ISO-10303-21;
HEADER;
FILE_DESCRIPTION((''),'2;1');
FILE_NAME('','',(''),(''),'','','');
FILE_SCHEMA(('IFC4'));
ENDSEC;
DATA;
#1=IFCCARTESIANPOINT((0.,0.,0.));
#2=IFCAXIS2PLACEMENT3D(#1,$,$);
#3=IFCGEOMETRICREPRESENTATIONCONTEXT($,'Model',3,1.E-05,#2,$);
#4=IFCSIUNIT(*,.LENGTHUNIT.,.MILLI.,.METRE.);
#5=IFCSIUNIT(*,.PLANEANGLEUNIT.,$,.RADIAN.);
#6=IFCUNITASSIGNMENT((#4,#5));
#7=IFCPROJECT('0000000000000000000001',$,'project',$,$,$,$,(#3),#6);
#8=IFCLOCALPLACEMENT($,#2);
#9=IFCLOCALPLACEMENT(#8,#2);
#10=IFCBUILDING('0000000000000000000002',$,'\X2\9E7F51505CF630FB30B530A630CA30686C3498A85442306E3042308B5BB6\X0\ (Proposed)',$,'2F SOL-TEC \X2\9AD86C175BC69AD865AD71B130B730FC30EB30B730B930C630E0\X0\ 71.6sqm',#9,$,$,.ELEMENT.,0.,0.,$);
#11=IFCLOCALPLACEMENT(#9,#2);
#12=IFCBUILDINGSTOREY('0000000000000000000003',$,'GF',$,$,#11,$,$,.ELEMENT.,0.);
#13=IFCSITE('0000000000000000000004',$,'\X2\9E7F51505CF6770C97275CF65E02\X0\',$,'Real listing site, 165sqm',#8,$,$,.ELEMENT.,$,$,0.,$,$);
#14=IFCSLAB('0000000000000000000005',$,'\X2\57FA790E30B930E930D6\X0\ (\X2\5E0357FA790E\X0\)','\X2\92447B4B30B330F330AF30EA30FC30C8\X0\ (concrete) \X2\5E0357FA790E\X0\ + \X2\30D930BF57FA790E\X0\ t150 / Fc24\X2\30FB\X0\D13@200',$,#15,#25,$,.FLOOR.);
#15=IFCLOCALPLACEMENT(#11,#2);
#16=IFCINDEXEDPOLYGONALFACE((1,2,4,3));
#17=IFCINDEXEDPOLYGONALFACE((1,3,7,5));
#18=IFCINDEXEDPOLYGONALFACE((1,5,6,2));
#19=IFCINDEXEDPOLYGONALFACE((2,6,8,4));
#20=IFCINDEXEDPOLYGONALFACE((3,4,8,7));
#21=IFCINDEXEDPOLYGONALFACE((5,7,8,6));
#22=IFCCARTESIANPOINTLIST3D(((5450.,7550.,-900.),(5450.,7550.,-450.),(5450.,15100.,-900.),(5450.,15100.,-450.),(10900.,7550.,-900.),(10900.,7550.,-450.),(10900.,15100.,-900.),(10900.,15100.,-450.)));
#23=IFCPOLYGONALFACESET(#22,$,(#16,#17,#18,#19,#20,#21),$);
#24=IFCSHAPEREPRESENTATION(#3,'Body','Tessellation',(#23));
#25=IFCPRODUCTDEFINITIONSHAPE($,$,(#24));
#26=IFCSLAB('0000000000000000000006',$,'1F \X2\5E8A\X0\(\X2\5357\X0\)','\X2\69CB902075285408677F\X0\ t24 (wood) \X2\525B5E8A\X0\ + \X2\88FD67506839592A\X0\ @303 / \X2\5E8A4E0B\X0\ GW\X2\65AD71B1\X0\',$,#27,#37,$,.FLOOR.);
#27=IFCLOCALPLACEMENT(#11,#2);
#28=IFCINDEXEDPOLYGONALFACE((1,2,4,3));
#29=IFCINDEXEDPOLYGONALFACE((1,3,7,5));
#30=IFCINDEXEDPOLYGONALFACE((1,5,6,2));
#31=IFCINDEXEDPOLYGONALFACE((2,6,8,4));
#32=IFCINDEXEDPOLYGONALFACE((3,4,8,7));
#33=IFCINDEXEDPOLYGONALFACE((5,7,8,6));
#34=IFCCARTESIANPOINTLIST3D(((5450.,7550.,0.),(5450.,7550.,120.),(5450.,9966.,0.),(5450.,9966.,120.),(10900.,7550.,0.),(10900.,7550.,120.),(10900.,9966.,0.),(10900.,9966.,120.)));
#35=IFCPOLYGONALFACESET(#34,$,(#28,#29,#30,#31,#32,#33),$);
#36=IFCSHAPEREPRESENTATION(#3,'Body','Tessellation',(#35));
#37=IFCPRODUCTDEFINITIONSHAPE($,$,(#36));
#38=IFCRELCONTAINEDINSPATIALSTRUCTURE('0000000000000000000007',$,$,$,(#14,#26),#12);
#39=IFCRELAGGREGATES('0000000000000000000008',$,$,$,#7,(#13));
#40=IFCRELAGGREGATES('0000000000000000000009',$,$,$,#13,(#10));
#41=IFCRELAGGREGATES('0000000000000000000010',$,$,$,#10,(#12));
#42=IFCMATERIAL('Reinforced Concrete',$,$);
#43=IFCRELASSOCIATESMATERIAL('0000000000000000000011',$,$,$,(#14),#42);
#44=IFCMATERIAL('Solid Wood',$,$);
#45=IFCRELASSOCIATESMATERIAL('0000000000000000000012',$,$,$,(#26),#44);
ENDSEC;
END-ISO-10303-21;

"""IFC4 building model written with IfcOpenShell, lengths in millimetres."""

from ifc_helpers import new_model, si_unit, frame, frame_2d, origin, place, context, project, spatial, rectangle, extrude, material, element, save


model = new_model("IFC4")

# Units and contexts
model_context = context("Model", 3, precision=1e-05, world=origin())
ifc_project = project(units=[si_unit("LENGTHUNIT", "METRE", prefix="MILLI"), si_unit("PLANEANGLEUNIT", "RADIAN")], contexts=[model_context])

# Site, building, storey
site_placement = place(None, origin())
site = spatial("IfcSite", under=ifc_project, at=site_placement, Name="鹿児島県霧島市", ObjectType="Real listing site, 165sqm", CompositionType="ELEMENT", RefElevation=0.0)
building_placement = place(site_placement, origin())
building = spatial("IfcBuilding", under=site, at=building_placement, Name="鹿児島・サウナと水風呂のある家 (Proposed)", ObjectType="2F SOL-TEC 高気密高断熱シールシステム 71.6sqm", CompositionType="ELEMENT", ElevationOfRefHeight=0.0, ElevationOfTerrain=0.0)
storey_placement = place(building_placement, origin())
storey = spatial("IfcBuildingStorey", under=building, at=storey_placement, Name="GF", CompositionType="ELEMENT", Elevation=0.0)

# Shared definitions
ifc_material_1 = material(Name="Solid Wood")

# Slabs
ifc_material_2 = material(Name="Reinforced Concrete")
slab_1_placement = place(storey_placement, frame((2725.0, 3775.0, -450.0)))
element("IfcSlab", 1, at=slab_1_placement, inside=storey, material=ifc_material_2, Name="基礎スラブ (布基礎)", Description="鉄筋コンクリート (concrete) 布基礎 + ベタ基礎 t150 / Fc24・D13@200", PredefinedType="FLOOR", context=model_context, shape_type="SweptSolid", body=[
    extrude(rectangle(XDim=5450.0, YDim=7550.0, at=frame_2d((2725.0, 3775.0))), frame((2725.0, 3775.0, -450.0)), (0.0, 0.0, 1.0), 450.0),
])
slab_2_placement = place(storey_placement, frame((2725.0, 3775.0, 0.0)))
element("IfcSlab", 2, at=slab_2_placement, inside=storey, material=ifc_material_1, Name="1F 床(南)", Description="構造用合板 t24 (wood) 剛床 + 製材根太 @303 / 床下 GW断熱", PredefinedType="FLOOR", context=model_context, shape_type="SweptSolid", body=[
    extrude(rectangle(XDim=5450.0, YDim=2416.0, at=frame_2d((2725.0, 1208.0))), frame((2725.0, 3775.0, 0.0)), (0.0, 0.0, 1.0), 120.0),
])

save(model, "model.ifc")
